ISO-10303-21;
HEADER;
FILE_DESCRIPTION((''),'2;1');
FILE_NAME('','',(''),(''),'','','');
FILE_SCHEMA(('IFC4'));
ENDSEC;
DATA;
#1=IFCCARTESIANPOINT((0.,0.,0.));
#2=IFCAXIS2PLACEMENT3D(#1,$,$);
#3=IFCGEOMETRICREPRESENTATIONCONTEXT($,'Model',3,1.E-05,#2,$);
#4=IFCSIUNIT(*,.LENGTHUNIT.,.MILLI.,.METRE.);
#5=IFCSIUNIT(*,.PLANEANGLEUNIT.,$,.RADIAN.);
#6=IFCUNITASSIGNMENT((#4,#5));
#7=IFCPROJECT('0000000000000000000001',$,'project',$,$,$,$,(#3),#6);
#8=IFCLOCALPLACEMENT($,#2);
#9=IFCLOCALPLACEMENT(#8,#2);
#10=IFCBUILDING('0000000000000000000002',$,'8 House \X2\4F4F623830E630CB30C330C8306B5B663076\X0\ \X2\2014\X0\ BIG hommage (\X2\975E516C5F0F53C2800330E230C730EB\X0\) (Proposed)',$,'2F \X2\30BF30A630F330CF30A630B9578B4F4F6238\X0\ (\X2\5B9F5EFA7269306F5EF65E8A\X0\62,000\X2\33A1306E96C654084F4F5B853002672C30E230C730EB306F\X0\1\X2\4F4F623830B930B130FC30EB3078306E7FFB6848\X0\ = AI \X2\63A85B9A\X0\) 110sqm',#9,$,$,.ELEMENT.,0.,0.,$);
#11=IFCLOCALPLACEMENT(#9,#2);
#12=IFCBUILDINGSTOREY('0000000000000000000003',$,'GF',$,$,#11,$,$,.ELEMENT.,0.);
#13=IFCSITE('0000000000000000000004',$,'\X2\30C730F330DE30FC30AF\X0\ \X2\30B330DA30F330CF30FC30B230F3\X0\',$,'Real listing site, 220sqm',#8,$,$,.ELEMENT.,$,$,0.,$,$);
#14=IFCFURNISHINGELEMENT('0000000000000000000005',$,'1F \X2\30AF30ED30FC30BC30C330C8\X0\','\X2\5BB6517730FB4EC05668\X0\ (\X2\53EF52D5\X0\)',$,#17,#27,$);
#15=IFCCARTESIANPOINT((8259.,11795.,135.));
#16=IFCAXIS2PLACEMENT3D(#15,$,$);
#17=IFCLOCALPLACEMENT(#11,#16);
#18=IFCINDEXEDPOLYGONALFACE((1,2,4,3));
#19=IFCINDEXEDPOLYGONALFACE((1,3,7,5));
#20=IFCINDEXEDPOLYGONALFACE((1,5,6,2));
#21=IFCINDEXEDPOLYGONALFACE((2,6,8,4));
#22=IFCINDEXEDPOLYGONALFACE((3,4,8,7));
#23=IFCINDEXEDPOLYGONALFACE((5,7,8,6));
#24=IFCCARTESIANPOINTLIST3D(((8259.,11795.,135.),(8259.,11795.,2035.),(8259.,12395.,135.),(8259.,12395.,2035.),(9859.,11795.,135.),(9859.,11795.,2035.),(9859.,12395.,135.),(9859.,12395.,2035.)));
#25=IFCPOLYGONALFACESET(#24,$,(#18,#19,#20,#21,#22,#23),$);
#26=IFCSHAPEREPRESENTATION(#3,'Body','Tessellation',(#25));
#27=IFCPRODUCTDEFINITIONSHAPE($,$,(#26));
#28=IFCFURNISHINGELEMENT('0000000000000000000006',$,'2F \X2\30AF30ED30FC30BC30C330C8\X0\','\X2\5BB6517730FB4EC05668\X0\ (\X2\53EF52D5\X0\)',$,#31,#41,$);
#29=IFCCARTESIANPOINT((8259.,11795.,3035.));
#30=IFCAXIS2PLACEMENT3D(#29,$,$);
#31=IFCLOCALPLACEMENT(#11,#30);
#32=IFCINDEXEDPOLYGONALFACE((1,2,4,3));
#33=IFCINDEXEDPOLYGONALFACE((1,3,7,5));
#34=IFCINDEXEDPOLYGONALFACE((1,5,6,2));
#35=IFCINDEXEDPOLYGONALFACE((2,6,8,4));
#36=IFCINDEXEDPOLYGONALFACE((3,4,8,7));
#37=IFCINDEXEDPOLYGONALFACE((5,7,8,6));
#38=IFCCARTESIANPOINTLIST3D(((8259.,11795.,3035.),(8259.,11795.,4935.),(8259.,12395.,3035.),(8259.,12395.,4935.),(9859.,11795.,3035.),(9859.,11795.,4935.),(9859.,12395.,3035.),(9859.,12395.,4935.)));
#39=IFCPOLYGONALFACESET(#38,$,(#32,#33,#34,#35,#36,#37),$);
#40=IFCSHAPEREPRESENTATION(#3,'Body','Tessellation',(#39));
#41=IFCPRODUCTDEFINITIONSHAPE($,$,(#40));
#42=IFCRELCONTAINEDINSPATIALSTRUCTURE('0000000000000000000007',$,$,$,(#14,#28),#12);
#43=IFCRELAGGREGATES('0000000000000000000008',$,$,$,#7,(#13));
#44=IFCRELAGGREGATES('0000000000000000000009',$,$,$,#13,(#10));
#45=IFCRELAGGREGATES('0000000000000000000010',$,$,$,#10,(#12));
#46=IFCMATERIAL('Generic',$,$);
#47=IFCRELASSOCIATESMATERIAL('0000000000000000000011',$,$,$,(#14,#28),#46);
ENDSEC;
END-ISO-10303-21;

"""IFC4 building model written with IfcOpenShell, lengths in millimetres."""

from ifc_helpers import new_model, si_unit, frame, frame_2d, origin, place, context, project, spatial, rectangle, extrude, material, element, save


model = new_model("IFC4")

# Units and contexts
model_context = context("Model", 3, precision=1e-05, world=origin())
ifc_project = project(units=[si_unit("LENGTHUNIT", "METRE", prefix="MILLI"), si_unit("PLANEANGLEUNIT", "RADIAN")], contexts=[model_context])

# Site, building, storey
site_placement = place(None, origin())
site = spatial("IfcSite", under=ifc_project, at=site_placement, Name="デンマーク コペンハーゲン", ObjectType="Real listing site, 220sqm", CompositionType="ELEMENT", RefElevation=0.0)
building_placement = place(site_placement, origin())
building = spatial("IfcBuilding", under=site, at=building_placement, Name="8 House 住戸ユニットに学ぶ — BIG hommage (非公式参考モデル) (Proposed)", ObjectType="2F タウンハウス型住戸 (実建物は延床62,000㎡の集合住宅。本モデルは1住戸スケールへの翻案 = AI 推定) 110sqm", CompositionType="ELEMENT", ElevationOfRefHeight=0.0, ElevationOfTerrain=0.0)
storey_placement = place(building_placement, origin())
storey = spatial("IfcBuildingStorey", under=building, at=storey_placement, Name="GF", CompositionType="ELEMENT", Elevation=0.0)

# Shared definitions
ifc_material_1 = material(Name="Generic")

# Furnishing elements
furnishing_1_placement = place(storey_placement, frame((8259.0, 11795.0, 135.0)))
element("IfcFurnishingElement", 1, at=furnishing_1_placement, inside=storey, material=ifc_material_1, Name="1F クローゼット", Description="家具・什器 (可動)", context=model_context, shape_type="SweptSolid", body=[
    extrude(rectangle(XDim=1600.0, YDim=600.0, at=frame_2d((800.0, 300.0))), frame((8259.0, 11795.0, 135.0)), (0.0, 0.0, 1.0), 1900.0),
])
furnishing_2_placement = place(storey_placement, frame((8259.0, 11795.0, 3035.0)))
element("IfcFurnishingElement", 2, at=furnishing_2_placement, inside=storey, material=ifc_material_1, Name="2F クローゼット", Description="家具・什器 (可動)", context=model_context, shape_type="SweptSolid", body=[
    extrude(rectangle(XDim=1600.0, YDim=600.0, at=frame_2d((800.0, 300.0))), frame((8259.0, 11795.0, 3035.0)), (0.0, 0.0, 1.0), 1900.0),
])

save(model, "model.ifc")
